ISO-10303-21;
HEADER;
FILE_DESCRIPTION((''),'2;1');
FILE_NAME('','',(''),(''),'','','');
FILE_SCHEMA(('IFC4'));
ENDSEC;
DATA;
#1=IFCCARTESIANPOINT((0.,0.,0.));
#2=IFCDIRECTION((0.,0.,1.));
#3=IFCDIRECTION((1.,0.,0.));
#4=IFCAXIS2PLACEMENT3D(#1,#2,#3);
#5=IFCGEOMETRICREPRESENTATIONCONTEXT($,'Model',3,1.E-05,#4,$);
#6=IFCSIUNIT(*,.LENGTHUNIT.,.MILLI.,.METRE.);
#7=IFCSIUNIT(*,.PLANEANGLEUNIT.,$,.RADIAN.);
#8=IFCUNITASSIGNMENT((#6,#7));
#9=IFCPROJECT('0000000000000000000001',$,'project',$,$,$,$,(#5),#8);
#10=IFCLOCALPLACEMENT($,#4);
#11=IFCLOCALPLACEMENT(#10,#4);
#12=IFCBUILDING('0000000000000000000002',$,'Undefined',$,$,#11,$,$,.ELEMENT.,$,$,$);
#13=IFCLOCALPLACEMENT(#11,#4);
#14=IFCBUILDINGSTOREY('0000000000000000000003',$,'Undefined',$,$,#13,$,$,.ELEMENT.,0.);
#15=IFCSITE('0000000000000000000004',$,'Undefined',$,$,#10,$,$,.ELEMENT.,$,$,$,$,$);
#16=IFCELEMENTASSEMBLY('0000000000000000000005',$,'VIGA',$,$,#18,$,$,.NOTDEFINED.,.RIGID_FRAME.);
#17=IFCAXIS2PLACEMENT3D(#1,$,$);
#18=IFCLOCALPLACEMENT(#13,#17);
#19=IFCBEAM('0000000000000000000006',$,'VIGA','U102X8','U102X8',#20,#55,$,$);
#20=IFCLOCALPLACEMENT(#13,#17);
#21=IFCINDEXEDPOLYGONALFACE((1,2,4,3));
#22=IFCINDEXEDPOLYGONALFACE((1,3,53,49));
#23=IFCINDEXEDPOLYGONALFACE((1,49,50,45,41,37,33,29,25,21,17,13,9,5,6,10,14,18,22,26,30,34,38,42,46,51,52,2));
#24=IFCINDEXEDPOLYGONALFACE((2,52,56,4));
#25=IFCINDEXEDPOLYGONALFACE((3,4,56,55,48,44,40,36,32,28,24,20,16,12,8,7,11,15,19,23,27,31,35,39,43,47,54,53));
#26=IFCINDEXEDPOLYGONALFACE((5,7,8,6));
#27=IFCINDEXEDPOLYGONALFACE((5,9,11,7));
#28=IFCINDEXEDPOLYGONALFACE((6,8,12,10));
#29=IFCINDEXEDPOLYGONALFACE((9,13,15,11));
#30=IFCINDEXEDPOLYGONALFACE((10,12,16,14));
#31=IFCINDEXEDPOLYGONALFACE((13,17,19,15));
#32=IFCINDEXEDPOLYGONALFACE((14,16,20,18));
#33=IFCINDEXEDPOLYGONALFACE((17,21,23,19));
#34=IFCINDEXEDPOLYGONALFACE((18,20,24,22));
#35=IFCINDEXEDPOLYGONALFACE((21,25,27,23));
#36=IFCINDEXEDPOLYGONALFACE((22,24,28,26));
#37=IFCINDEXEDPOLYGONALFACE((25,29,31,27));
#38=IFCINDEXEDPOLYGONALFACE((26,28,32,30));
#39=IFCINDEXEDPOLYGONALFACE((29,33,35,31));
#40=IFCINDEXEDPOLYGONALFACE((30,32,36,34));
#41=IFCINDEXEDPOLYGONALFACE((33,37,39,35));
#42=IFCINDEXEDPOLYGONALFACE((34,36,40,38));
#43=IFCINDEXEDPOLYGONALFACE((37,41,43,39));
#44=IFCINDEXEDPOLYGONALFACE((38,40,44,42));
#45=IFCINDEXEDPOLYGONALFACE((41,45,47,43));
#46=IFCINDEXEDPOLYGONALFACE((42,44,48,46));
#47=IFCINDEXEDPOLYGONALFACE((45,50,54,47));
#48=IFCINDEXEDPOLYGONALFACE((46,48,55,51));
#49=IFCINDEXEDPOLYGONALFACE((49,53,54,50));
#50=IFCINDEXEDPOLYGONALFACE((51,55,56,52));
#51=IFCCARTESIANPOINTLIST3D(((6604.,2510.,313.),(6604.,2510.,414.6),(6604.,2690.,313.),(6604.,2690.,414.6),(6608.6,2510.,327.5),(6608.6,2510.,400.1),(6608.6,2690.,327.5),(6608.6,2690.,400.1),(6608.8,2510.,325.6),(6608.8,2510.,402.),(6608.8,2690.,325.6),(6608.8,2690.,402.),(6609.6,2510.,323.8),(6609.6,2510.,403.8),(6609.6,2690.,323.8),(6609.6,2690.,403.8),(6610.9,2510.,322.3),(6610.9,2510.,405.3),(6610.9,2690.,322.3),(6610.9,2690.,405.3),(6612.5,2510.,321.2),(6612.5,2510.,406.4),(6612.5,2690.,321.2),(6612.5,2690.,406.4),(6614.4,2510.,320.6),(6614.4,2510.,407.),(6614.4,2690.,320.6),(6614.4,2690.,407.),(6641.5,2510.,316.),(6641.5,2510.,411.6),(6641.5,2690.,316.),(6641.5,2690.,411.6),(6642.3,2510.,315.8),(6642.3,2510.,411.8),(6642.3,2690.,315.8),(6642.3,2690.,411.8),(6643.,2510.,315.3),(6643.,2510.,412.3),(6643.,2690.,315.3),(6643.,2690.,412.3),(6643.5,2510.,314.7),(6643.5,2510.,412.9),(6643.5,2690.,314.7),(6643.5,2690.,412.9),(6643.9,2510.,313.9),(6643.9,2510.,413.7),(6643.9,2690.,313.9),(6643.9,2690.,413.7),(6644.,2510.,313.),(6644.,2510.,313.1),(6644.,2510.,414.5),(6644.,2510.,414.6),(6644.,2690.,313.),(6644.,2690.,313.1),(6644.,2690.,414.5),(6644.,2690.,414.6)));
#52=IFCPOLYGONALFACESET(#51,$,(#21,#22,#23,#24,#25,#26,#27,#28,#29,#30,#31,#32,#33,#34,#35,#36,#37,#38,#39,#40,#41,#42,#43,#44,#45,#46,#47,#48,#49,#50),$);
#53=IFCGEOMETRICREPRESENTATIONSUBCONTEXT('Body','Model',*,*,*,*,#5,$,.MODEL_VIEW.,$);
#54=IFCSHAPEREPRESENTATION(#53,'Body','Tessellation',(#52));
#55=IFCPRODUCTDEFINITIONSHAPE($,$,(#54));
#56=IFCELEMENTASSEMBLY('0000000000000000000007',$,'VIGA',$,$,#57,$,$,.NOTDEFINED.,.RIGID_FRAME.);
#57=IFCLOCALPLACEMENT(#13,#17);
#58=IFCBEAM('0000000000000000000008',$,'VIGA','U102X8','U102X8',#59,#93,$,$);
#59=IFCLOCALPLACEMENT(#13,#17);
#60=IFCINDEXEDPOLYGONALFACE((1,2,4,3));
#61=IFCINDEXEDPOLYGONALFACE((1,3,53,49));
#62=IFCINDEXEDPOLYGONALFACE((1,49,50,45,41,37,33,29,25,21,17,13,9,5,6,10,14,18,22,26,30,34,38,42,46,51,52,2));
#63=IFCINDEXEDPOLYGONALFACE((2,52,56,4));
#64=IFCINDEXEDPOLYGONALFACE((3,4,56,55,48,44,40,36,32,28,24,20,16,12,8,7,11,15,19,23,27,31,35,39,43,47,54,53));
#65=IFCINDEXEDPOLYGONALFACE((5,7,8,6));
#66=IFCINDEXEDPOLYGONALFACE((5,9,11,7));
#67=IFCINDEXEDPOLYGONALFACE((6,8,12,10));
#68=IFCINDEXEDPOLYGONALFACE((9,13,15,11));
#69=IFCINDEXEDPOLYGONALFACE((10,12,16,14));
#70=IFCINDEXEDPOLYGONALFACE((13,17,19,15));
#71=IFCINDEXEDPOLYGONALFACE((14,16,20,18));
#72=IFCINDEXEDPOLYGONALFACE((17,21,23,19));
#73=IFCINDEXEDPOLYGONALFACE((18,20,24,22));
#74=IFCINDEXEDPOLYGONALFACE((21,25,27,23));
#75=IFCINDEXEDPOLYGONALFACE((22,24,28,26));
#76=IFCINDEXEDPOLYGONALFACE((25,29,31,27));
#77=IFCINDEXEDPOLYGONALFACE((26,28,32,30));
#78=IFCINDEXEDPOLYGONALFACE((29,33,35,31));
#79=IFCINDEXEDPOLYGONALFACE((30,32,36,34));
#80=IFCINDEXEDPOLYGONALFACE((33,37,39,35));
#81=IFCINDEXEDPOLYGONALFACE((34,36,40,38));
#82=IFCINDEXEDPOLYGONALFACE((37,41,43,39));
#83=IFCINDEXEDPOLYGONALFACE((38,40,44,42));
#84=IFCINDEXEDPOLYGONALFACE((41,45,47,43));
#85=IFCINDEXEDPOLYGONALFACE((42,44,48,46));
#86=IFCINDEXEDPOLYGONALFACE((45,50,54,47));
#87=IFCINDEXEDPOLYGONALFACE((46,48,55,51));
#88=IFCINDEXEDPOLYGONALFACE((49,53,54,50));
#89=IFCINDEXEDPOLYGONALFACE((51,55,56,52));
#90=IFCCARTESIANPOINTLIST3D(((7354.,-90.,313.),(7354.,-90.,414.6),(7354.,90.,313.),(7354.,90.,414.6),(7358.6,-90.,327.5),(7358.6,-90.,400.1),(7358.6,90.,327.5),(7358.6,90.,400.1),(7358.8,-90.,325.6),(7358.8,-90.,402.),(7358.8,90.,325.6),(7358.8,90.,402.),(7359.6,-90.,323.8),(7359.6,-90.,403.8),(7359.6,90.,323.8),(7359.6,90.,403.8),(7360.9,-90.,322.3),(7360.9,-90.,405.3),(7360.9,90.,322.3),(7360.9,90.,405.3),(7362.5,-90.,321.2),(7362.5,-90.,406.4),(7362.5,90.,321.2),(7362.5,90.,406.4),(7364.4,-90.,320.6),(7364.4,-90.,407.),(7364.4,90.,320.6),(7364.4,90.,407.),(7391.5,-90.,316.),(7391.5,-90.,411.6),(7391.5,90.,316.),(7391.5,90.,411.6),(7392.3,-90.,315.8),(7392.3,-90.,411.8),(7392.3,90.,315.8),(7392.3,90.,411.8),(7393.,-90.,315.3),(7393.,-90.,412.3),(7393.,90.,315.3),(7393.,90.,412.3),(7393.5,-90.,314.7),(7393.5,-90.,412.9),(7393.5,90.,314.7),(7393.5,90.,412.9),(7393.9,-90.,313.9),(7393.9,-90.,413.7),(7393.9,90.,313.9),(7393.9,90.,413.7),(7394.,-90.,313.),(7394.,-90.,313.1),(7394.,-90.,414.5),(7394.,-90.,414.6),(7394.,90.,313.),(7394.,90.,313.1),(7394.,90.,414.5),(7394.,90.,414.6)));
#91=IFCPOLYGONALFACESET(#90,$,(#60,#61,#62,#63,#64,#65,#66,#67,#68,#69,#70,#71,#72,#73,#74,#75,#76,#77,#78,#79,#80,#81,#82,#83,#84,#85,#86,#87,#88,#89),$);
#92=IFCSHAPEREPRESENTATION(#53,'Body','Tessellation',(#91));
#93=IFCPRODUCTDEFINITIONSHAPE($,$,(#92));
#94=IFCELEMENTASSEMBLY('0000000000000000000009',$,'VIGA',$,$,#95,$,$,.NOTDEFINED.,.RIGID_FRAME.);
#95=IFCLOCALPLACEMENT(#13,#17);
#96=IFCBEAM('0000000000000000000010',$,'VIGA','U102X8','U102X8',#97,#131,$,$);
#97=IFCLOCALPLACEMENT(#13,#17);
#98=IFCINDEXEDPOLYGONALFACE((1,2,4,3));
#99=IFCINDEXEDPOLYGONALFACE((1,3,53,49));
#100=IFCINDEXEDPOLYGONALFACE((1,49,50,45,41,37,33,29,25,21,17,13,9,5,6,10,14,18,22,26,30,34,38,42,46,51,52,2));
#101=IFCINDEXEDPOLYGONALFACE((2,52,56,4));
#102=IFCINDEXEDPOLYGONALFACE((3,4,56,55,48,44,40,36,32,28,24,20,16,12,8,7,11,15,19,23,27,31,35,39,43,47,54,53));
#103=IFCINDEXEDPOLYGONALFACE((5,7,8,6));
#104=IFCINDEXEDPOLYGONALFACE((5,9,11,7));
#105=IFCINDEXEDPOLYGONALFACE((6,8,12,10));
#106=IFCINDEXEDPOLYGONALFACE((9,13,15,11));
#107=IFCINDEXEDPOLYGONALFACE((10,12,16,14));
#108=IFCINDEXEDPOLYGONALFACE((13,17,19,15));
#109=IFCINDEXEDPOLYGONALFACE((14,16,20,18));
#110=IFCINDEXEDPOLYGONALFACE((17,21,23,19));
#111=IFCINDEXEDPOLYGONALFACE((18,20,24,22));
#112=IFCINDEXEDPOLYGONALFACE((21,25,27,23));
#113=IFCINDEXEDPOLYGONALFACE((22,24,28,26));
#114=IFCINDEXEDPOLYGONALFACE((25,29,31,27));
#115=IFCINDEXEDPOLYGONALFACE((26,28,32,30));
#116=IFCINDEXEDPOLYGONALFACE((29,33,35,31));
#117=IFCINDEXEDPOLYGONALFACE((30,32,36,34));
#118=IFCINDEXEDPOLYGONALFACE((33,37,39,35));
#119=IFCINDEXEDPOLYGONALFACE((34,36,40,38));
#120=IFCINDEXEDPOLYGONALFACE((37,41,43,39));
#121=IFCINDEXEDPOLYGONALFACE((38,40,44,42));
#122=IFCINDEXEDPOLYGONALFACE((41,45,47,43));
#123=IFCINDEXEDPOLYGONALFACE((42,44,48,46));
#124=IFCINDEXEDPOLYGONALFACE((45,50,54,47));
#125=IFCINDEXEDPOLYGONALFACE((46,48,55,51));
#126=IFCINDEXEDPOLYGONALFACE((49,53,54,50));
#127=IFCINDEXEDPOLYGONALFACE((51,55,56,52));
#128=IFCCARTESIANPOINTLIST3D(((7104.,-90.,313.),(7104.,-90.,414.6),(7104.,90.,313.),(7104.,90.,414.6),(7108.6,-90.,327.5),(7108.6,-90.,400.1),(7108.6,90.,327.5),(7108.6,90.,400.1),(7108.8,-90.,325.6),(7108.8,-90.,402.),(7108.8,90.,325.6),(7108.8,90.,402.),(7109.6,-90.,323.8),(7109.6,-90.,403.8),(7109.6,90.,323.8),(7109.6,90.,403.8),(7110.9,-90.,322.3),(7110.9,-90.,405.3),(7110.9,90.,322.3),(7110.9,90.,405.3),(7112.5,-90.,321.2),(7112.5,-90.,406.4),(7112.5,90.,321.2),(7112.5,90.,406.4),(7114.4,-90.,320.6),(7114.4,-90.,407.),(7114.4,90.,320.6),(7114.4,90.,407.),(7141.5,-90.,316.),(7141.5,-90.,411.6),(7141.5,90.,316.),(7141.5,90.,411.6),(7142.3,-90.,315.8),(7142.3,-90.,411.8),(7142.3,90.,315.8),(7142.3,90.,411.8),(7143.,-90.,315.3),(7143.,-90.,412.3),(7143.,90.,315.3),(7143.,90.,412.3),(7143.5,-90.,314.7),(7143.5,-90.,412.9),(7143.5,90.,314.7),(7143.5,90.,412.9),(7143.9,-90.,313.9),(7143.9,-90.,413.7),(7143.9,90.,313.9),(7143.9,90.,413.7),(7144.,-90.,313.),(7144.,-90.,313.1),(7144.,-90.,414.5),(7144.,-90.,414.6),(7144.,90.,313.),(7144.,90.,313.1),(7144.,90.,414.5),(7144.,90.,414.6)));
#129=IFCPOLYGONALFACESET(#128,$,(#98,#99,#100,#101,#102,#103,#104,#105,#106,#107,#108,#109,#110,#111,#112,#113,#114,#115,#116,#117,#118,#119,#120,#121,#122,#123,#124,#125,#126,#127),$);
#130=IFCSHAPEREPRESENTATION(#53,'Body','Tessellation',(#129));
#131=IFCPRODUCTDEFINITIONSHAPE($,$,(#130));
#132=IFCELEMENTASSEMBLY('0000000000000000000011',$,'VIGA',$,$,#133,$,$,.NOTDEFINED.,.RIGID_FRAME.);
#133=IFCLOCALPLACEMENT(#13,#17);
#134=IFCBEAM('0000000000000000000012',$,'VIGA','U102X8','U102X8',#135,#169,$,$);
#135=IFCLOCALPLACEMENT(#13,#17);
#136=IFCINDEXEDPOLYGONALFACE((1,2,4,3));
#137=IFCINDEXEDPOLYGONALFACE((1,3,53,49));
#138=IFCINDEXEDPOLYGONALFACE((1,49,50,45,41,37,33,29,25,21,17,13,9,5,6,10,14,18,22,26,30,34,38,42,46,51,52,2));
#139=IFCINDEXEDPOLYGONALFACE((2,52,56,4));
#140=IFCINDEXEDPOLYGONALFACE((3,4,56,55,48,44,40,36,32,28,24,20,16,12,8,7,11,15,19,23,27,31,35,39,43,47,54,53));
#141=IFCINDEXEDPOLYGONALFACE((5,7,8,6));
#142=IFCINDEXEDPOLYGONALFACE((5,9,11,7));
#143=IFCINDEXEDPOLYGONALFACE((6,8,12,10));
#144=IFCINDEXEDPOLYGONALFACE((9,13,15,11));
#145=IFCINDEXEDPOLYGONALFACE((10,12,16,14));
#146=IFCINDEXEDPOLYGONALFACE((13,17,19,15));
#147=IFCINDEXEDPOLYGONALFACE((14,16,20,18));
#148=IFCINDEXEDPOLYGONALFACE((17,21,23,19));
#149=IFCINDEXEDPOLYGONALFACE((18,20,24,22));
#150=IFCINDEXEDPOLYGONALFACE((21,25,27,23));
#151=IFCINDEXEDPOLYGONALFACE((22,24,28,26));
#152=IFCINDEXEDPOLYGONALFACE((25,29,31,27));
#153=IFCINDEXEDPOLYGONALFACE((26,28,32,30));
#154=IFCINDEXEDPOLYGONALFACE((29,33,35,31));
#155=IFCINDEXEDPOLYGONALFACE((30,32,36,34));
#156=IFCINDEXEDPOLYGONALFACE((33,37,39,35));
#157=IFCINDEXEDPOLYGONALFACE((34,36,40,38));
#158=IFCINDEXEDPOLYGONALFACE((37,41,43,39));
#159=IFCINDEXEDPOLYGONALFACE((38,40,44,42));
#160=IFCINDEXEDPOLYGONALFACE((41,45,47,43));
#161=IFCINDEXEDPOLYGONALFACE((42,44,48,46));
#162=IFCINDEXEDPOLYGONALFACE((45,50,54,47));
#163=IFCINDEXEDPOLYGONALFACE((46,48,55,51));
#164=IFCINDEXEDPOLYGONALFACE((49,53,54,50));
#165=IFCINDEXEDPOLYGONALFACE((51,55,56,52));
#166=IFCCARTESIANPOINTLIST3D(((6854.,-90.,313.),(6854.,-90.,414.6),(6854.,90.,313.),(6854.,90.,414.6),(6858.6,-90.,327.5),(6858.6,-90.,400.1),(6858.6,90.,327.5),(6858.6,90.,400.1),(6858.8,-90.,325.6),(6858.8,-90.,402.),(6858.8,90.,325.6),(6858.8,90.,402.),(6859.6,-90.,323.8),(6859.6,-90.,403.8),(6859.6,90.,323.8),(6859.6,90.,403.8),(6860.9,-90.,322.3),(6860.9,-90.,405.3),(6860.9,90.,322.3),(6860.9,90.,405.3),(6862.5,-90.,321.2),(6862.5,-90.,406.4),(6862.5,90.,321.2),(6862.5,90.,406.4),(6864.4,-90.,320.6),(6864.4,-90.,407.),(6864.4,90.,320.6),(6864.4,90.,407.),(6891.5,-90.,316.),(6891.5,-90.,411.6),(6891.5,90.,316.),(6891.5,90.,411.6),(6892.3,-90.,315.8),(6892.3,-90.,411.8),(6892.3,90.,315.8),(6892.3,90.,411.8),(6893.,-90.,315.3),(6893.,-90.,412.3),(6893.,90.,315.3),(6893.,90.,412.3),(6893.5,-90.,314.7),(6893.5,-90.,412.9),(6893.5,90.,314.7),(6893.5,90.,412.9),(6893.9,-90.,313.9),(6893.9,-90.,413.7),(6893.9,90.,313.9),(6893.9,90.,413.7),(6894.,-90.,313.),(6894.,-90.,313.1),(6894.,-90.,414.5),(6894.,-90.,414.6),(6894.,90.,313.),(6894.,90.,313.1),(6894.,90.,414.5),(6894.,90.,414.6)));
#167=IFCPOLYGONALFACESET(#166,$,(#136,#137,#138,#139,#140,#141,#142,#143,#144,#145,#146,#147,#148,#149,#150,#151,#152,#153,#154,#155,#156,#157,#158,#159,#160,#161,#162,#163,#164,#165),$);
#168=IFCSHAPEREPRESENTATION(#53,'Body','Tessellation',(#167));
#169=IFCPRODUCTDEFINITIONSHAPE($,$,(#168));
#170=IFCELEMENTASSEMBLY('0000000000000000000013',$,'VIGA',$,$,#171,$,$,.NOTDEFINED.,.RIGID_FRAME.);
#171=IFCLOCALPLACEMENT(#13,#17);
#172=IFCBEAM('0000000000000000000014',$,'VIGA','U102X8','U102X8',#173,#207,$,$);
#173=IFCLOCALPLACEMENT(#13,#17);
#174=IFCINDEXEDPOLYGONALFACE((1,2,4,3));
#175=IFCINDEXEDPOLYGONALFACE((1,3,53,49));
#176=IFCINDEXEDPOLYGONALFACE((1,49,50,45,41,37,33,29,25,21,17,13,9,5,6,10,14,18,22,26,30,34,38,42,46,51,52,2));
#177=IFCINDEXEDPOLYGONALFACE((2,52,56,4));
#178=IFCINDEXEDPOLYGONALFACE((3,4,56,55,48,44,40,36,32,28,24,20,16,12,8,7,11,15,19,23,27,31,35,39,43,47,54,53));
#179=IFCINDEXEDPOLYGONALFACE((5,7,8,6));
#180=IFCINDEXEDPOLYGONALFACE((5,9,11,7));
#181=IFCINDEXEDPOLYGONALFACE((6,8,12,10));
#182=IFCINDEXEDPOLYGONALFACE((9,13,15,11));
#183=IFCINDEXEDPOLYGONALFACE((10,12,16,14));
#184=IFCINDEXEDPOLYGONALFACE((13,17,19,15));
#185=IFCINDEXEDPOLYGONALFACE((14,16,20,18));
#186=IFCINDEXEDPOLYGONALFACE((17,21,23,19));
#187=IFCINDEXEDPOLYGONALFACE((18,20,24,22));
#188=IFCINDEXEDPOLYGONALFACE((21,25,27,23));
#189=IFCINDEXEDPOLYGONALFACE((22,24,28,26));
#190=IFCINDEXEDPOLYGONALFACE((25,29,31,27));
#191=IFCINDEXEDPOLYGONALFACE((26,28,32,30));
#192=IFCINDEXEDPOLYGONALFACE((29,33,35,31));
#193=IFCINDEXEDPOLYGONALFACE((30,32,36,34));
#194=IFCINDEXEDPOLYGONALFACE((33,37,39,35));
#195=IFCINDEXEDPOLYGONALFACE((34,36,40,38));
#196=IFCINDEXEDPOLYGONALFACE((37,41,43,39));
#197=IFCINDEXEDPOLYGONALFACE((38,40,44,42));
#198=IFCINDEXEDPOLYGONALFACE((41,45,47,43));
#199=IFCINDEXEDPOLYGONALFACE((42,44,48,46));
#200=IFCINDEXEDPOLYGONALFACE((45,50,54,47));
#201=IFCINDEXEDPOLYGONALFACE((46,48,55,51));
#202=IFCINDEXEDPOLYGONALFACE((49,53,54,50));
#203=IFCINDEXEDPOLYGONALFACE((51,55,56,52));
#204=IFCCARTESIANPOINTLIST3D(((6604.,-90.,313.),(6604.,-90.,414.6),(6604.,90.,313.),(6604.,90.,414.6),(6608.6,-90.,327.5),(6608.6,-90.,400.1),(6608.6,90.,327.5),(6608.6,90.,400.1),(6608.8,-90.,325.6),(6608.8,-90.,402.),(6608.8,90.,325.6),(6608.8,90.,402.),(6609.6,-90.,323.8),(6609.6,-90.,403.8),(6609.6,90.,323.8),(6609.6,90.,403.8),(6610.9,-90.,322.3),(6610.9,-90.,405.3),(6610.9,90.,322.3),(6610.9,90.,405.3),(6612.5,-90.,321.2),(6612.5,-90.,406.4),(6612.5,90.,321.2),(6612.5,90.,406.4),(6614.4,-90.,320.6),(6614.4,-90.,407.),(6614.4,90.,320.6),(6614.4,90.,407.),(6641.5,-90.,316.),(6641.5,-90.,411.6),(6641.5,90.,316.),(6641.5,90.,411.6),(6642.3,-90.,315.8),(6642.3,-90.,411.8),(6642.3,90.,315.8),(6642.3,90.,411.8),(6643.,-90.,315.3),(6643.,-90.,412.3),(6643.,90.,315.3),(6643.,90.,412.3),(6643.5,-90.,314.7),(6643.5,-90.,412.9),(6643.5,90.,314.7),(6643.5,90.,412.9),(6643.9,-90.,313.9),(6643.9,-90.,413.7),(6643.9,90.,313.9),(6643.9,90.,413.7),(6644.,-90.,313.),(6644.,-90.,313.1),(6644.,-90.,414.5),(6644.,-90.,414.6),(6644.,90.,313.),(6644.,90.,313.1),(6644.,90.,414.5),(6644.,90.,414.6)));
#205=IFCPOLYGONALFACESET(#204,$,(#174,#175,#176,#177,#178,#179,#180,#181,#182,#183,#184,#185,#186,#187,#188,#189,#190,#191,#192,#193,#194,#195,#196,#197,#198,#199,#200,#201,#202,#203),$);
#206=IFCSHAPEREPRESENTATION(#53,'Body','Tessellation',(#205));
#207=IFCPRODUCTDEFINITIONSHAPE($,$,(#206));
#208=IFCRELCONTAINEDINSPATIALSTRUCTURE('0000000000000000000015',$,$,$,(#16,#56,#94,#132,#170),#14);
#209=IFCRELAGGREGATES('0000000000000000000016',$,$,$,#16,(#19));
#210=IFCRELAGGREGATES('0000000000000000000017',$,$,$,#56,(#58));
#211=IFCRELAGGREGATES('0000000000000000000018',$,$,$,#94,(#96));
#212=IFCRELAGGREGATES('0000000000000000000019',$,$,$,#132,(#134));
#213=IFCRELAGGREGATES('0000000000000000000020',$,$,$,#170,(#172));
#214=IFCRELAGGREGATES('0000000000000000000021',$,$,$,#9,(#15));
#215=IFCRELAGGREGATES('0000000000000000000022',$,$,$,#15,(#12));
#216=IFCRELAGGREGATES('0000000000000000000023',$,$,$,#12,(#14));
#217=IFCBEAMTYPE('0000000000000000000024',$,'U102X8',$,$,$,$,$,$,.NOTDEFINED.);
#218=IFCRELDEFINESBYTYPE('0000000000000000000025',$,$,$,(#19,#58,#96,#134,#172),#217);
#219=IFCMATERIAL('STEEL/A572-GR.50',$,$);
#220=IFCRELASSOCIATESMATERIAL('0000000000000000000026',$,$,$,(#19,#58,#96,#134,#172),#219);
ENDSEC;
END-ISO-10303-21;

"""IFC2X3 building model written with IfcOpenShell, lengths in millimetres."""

from ifc_helpers import new_model, si_unit, frame, origin_with_axes, origin_2d_with_axis, place, context, subcontext, project, spatial, u_section, extrude, material, type_object, element, aggregate, save


model = new_model("IFC2X3")

# Units and contexts
model_context = context("Model", 3, precision=1e-05, world=origin_with_axes())
body_context = subcontext(model_context, "Body", "Model", "MODEL_VIEW")
ifc_project = project(units=[si_unit("LENGTHUNIT", "METRE", prefix="MILLI"), si_unit("PLANEANGLEUNIT", "RADIAN")], contexts=[model_context])

# Site, building, storey
site_placement = place(None, origin_with_axes())
site = spatial("IfcSite", under=ifc_project, at=site_placement, Name="Undefined", CompositionType="ELEMENT")
building_placement = place(site_placement, origin_with_axes())
building = spatial("IfcBuilding", under=site, at=building_placement, Name="Undefined", CompositionType="ELEMENT")
storey_placement = place(building_placement, origin_with_axes())
storey = spatial("IfcBuildingStorey", under=building, at=storey_placement, Name="Undefined", CompositionType="ELEMENT", Elevation=0.0)

# Element assemblies, beams
ifc_material_1 = material(Name="STEEL/A572-GR.50")
beam_type_1 = type_object("IfcBeamType", Name="U102X8", PredefinedType="NOTDEFINED")
assembly_1_placement = place(storey_placement, origin_with_axes())
assembly_1 = element("IfcElementAssembly", 1, at=assembly_1_placement, inside=storey, Name="VIGA", AssemblyPlace="NOTDEFINED", PredefinedType="RIGID_FRAME")
beam_1_placement = place(assembly_1_placement, frame((6624.0, 2510.0, 363.8), z_axis=(0.0, 0.0, 1.0), x_axis=(0.0, 1.0, 0.0)))
beam_1 = element("IfcBeam", 2, at=beam_1_placement, type_object=beam_type_1, material=ifc_material_1, Name="VIGA", Description="U102X8", ObjectType="U102X8", context=body_context, shape_type="SweptSolid", body=[
    extrude(u_section(Depth=101.6, FlangeWidth=40.0, WebThickness=4.6, FlangeThickness=6.0, FilletRadius=7.0, EdgeRadius=3.0, FlangeSlope=0.16839, at=origin_2d_with_axis()), frame((180.0, 0.0, 0.0), z_axis=(-1.0, 0.0, 0.0), x_axis=(0.0, -1.0, 0.0)), (0.0, 0.0, 1.0), 180.0),
])
aggregate(assembly_1, [beam_1])
assembly_2_placement = place(storey_placement, origin_with_axes())
assembly_2 = element("IfcElementAssembly", 3, at=assembly_2_placement, inside=storey, Name="VIGA", AssemblyPlace="NOTDEFINED", PredefinedType="RIGID_FRAME")
beam_2_placement = place(assembly_2_placement, frame((7374.0, -90.0, 363.8), z_axis=(0.0, 0.0, 1.0), x_axis=(0.0, 1.0, 0.0)))
beam_2 = element("IfcBeam", 4, at=beam_2_placement, type_object=beam_type_1, material=ifc_material_1, Name="VIGA", Description="U102X8", ObjectType="U102X8", context=body_context, shape_type="SweptSolid", body=[
    extrude(u_section(Depth=101.6, FlangeWidth=40.0, WebThickness=4.6, FlangeThickness=6.0, FilletRadius=7.0, EdgeRadius=3.0, FlangeSlope=0.16839, at=origin_2d_with_axis()), frame((180.0, 0.0, 0.0), z_axis=(-1.0, 0.0, 0.0), x_axis=(0.0, -1.0, 0.0)), (0.0, 0.0, 1.0), 180.0),
])
aggregate(assembly_2, [beam_2])
assembly_3_placement = place(storey_placement, origin_with_axes())
assembly_3 = element("IfcElementAssembly", 5, at=assembly_3_placement, inside=storey, Name="VIGA", AssemblyPlace="NOTDEFINED", PredefinedType="RIGID_FRAME")
beam_3_placement = place(assembly_3_placement, frame((7124.0, -90.0, 363.8), z_axis=(0.0, 0.0, 1.0), x_axis=(0.0, 1.0, 0.0)))
beam_3 = element("IfcBeam", 6, at=beam_3_placement, type_object=beam_type_1, material=ifc_material_1, Name="VIGA", Description="U102X8", ObjectType="U102X8", context=body_context, shape_type="SweptSolid", body=[
    extrude(u_section(Depth=101.6, FlangeWidth=40.0, WebThickness=4.6, FlangeThickness=6.0, FilletRadius=7.0, EdgeRadius=3.0, FlangeSlope=0.16839, at=origin_2d_with_axis()), frame((180.0, 0.0, 0.0), z_axis=(-1.0, 0.0, 0.0), x_axis=(0.0, -1.0, 0.0)), (0.0, 0.0, 1.0), 180.0),
])
aggregate(assembly_3, [beam_3])
assembly_4_placement = place(storey_placement, origin_with_axes())
assembly_4 = element("IfcElementAssembly", 7, at=assembly_4_placement, inside=storey, Name="VIGA", AssemblyPlace="NOTDEFINED", PredefinedType="RIGID_FRAME")
beam_4_placement = place(assembly_4_placement, frame((6874.0, -90.0, 363.8), z_axis=(0.0, 0.0, 1.0), x_axis=(0.0, 1.0, 0.0)))
beam_4 = element("IfcBeam", 8, at=beam_4_placement, type_object=beam_type_1, material=ifc_material_1, Name="VIGA", Description="U102X8", ObjectType="U102X8", context=body_context, shape_type="SweptSolid", body=[
    extrude(u_section(Depth=101.6, FlangeWidth=40.0, WebThickness=4.6, FlangeThickness=6.0, FilletRadius=7.0, EdgeRadius=3.0, FlangeSlope=0.16839, at=origin_2d_with_axis()), frame((180.0, 0.0, 0.0), z_axis=(-1.0, 0.0, 0.0), x_axis=(0.0, -1.0, 0.0)), (0.0, 0.0, 1.0), 180.0),
])
aggregate(assembly_4, [beam_4])
assembly_5_placement = place(storey_placement, origin_with_axes())
assembly_5 = element("IfcElementAssembly", 9, at=assembly_5_placement, inside=storey, Name="VIGA", AssemblyPlace="NOTDEFINED", PredefinedType="RIGID_FRAME")
beam_5_placement = place(assembly_5_placement, frame((6624.0, -90.0, 363.8), z_axis=(0.0, 0.0, 1.0), x_axis=(0.0, 1.0, 0.0)))
beam_5 = element("IfcBeam", 10, at=beam_5_placement, type_object=beam_type_1, material=ifc_material_1, Name="VIGA", Description="U102X8", ObjectType="U102X8", context=body_context, shape_type="SweptSolid", body=[
    extrude(u_section(Depth=101.6, FlangeWidth=40.0, WebThickness=4.6, FlangeThickness=6.0, FilletRadius=7.0, EdgeRadius=3.0, FlangeSlope=0.16839, at=origin_2d_with_axis()), frame((180.0, 0.0, 0.0), z_axis=(-1.0, 0.0, 0.0), x_axis=(0.0, -1.0, 0.0)), (0.0, 0.0, 1.0), 180.0),
])
aggregate(assembly_5, [beam_5])

save(model, "model.ifc")
